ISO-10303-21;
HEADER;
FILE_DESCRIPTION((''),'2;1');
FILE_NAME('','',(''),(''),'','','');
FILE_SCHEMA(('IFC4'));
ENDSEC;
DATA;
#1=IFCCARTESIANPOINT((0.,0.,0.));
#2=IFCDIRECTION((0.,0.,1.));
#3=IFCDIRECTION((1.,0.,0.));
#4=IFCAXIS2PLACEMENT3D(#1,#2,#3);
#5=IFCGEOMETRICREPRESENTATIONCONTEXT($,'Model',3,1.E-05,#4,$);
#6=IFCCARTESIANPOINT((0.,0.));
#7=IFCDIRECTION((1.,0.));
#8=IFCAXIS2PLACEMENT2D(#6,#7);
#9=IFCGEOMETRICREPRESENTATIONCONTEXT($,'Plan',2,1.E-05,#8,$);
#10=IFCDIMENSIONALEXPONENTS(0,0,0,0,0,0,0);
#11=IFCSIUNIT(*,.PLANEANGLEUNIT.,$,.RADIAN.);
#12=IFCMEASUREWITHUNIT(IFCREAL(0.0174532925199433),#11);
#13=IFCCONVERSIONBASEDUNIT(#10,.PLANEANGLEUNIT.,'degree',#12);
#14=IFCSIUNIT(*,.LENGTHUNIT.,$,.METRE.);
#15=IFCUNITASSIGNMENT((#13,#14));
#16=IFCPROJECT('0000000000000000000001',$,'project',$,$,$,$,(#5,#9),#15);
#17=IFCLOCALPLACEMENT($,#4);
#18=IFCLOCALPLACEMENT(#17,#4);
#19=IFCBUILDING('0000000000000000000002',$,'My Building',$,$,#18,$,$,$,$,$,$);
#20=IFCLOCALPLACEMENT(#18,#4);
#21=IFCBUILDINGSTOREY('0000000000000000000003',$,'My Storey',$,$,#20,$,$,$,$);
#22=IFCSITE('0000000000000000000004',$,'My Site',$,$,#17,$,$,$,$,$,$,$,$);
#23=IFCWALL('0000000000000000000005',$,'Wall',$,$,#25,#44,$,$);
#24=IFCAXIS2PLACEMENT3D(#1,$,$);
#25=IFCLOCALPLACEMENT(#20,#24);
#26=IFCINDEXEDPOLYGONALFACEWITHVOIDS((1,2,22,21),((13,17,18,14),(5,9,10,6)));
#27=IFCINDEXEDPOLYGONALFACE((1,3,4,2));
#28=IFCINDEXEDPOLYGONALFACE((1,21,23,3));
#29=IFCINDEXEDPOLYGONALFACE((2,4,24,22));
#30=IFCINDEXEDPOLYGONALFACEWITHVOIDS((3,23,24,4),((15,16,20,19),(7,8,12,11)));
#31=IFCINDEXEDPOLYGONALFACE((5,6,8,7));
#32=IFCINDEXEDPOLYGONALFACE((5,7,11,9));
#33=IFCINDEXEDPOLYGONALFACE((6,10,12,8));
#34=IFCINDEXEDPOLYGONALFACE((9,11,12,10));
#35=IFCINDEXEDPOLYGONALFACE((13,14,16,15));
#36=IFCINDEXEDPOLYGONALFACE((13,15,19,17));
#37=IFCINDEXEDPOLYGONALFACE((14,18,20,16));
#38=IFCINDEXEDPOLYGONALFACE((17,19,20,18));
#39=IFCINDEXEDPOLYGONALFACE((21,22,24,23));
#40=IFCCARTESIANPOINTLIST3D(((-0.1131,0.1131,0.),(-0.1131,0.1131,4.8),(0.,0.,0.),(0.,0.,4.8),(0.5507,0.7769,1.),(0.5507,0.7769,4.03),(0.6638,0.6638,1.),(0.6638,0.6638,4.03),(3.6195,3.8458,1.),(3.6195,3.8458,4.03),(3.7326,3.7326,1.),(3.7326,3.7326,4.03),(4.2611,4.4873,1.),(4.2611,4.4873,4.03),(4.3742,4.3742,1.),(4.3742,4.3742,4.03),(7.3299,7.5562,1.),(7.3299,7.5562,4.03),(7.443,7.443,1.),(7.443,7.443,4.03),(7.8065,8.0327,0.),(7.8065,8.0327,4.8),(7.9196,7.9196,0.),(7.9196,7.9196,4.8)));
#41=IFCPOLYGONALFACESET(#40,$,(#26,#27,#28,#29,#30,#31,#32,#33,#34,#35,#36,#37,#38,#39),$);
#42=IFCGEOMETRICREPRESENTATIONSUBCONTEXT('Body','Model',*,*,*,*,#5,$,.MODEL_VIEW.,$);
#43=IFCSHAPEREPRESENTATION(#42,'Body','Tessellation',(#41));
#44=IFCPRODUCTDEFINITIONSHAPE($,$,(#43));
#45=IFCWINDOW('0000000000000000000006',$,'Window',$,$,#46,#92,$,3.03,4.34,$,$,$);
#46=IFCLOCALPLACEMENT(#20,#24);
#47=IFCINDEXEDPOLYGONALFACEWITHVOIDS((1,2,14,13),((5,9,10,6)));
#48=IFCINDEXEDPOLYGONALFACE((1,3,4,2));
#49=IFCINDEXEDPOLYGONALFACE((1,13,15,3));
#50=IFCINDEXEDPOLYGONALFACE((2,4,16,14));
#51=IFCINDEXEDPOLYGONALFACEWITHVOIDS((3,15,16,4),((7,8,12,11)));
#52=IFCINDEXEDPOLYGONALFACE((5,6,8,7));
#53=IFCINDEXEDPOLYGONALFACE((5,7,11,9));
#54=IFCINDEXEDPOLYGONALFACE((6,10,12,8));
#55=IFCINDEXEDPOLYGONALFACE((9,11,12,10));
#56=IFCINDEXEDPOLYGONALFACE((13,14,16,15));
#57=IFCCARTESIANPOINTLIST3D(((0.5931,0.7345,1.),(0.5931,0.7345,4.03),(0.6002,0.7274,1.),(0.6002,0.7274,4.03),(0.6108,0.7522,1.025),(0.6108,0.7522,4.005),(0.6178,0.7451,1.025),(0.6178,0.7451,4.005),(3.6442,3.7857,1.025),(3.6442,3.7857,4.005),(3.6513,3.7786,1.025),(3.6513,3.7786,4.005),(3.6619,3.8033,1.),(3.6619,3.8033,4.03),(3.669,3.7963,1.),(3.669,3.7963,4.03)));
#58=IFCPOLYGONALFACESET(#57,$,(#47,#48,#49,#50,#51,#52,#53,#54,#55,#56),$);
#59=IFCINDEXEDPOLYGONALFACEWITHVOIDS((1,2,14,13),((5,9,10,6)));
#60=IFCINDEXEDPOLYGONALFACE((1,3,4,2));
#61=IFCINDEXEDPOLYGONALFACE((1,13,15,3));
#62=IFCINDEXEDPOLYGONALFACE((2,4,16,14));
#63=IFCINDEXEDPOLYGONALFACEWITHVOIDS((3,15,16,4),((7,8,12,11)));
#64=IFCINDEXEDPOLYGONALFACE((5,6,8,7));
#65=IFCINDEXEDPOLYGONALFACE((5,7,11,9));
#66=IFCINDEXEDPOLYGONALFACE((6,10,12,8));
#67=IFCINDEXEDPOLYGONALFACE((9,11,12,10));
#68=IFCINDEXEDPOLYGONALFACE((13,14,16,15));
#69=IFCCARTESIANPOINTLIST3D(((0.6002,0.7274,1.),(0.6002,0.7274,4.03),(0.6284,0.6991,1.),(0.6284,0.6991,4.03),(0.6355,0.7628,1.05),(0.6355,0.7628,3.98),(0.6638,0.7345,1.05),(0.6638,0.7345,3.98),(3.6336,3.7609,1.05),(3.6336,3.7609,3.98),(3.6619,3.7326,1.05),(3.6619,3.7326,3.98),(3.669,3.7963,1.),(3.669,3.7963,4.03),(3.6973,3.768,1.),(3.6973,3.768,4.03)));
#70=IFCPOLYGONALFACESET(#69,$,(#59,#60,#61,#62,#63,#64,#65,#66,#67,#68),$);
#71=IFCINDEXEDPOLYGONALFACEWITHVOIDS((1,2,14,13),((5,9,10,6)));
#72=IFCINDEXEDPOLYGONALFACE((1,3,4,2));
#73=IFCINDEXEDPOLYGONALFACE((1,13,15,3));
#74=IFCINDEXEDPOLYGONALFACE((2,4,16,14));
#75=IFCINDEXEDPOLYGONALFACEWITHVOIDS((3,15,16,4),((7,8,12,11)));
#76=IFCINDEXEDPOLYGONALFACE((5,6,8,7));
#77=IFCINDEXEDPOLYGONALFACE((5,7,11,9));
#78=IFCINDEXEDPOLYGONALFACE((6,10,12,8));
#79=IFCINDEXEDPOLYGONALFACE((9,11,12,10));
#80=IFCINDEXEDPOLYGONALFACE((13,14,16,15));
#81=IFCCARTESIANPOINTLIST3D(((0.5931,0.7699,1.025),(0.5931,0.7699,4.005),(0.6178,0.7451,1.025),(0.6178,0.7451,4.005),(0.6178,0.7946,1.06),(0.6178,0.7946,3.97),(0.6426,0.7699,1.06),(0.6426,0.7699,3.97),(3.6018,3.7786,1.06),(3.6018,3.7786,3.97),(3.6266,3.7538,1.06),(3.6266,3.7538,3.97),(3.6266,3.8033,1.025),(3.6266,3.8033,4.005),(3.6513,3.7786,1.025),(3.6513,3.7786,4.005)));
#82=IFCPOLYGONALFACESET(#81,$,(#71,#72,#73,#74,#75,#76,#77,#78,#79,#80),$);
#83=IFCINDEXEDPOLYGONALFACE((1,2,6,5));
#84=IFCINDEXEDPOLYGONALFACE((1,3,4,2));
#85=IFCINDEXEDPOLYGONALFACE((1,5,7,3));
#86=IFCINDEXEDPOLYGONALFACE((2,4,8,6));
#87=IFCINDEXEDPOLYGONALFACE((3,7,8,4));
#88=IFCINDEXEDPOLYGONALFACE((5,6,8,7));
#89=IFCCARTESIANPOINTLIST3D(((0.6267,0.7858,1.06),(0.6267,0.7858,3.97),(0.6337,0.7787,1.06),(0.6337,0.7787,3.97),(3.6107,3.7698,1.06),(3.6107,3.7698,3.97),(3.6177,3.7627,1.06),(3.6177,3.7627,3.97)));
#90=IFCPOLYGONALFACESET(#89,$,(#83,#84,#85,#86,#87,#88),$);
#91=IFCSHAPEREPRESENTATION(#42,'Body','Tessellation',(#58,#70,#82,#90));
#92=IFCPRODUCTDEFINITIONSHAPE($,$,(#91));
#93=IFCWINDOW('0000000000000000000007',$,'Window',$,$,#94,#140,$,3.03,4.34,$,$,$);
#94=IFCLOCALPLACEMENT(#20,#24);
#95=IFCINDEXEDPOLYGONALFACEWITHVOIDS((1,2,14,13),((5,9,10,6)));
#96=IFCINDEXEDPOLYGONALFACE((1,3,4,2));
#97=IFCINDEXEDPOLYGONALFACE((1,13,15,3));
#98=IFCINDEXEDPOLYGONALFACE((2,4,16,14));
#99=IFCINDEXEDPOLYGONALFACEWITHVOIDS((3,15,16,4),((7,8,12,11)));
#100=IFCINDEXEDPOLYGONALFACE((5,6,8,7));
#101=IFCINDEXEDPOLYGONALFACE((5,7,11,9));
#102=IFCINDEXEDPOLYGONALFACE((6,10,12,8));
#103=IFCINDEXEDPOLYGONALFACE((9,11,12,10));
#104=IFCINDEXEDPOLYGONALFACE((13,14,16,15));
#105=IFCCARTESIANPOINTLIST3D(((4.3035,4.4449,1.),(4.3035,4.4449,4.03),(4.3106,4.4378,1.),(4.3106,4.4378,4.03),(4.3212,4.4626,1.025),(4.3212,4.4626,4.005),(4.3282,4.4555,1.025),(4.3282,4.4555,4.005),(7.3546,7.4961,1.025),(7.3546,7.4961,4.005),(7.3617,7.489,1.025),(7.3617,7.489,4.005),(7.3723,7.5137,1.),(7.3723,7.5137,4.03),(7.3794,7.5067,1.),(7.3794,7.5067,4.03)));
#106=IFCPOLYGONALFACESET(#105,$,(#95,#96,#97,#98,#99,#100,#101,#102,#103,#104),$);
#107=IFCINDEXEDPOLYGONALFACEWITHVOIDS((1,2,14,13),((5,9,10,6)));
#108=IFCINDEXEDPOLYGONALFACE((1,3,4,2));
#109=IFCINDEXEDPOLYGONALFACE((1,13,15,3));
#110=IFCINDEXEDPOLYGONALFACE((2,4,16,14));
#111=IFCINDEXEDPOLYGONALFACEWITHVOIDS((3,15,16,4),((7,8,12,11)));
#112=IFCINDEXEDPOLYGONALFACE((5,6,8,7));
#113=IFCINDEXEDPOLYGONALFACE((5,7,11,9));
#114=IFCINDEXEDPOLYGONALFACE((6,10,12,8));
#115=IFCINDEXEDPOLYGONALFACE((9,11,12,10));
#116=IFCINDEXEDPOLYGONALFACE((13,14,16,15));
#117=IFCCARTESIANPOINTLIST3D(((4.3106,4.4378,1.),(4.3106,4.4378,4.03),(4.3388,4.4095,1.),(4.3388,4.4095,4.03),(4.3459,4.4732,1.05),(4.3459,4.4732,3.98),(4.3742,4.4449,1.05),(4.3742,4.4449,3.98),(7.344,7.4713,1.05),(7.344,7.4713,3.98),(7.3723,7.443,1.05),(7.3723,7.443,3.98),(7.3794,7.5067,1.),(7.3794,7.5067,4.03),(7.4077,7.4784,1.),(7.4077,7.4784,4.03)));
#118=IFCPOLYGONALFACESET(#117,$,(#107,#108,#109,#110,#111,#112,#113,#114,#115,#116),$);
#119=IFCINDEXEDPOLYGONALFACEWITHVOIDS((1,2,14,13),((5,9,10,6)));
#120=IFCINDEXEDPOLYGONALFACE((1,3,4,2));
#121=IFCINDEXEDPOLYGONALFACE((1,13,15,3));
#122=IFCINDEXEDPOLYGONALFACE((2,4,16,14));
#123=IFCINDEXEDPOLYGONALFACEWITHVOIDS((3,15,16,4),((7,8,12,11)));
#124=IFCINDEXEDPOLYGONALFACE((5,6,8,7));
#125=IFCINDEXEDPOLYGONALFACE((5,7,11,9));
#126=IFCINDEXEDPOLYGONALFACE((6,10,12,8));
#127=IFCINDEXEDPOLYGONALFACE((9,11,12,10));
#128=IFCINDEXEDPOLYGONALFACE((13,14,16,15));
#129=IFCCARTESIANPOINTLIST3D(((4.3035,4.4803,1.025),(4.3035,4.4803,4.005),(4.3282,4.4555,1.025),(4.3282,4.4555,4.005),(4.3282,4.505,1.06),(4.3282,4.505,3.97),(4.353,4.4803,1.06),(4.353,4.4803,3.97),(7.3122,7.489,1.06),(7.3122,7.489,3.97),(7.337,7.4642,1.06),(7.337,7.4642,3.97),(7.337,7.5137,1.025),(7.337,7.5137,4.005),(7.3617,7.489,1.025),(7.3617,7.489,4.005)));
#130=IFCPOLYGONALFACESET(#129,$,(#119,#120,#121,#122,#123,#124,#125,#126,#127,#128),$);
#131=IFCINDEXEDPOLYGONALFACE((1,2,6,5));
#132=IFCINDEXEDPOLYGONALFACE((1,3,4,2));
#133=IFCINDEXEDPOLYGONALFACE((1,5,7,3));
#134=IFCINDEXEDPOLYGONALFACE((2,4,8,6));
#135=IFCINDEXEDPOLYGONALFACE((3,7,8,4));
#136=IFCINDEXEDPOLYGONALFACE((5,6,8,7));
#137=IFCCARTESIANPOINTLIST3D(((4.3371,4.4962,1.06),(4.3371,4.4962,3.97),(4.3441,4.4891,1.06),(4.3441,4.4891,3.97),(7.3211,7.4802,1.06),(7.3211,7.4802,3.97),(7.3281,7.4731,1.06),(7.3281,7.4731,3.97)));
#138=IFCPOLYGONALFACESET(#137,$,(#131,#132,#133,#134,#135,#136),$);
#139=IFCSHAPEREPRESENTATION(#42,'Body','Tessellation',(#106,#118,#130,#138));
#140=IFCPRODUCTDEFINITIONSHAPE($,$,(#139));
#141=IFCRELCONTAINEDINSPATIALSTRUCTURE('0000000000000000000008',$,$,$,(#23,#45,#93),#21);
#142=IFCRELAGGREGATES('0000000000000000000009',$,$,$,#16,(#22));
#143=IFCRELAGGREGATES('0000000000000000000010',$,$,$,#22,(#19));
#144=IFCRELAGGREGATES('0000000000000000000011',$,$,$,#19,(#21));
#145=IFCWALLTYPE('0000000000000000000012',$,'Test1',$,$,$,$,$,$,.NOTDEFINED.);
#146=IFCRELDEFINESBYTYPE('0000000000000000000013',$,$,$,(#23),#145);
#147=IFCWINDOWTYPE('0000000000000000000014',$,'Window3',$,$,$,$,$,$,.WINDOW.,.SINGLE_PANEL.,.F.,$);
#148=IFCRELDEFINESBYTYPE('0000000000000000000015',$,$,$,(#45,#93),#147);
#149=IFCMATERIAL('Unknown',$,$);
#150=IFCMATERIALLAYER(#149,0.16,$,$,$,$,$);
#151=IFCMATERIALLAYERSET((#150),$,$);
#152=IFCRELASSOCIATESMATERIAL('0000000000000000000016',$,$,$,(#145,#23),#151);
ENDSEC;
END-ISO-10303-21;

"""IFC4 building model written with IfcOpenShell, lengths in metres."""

from ifc_helpers import new_model, entity, si_unit, converted_unit, frame, origin_with_axes, origin_2d_with_axis, place, context, subcontext, project, spatial, line, indexed_curve, outline, extrude, shape, source, transform, mapped, material, layer, layer_set, layer_usage, type_object, type_shapes, element, fill, save


model = new_model("IFC4")

# Units and contexts
model_context = context("Model", 3, precision=1e-05, world=origin_with_axes())
plan_context = context("Plan", 2, precision=1e-05, world=origin_2d_with_axis())
body_context_1 = subcontext(model_context, "Body", "Model", "MODEL_VIEW")
body_context_2 = subcontext(plan_context, "Body", "Plan", "PLAN_VIEW")
ifc_project = project(units=[converted_unit("PLANEANGLEUNIT", "degree", entity("IfcReal", 0.0174532925199433), si_unit("PLANEANGLEUNIT", "RADIAN"), dimensions=[0, 0, 0, 0, 0, 0, 0]), si_unit("LENGTHUNIT", "METRE")], contexts=[model_context, plan_context])

# Site, building, storey
site_placement = place(None, origin_with_axes())
site = spatial("IfcSite", under=ifc_project, at=site_placement, Name="My Site")
building_placement = place(site_placement, origin_with_axes())
building = spatial("IfcBuilding", under=site, at=building_placement, Name="My Building")
storey_placement = place(building_placement, origin_with_axes())
storey = spatial("IfcBuildingStorey", under=building, at=storey_placement, Name="My Storey")

# Wall, openings, windows
ifc_material = material(Name="Unknown")
ifc_layer = layer(ifc_material, 0.16)
ifc_layer_set = layer_set([ifc_layer])
ifc_layer_usage_1 = layer_usage(ifc_layer_set, "AXIS2", "POSITIVE", 0.0)
wall_type = type_object("IfcWallType", Name="Test1", PredefinedType="NOTDEFINED", material=ifc_layer_set)
wall_1_placement = place(storey_placement, frame((0.0, 0.0, 0.0), z_axis=(0.0, 0.0, 1.0), x_axis=(0.707107, 0.707107, 0.0)))
wall_1 = element("IfcWall", 1, at=wall_1_placement, inside=storey, type_object=wall_type, material=ifc_layer_usage_1, Name="Wall", context=body_context_1, shape_type="SweptSolid", body=[
    extrude(outline(indexed_curve([(0.0, 0.0), (0.0, 0.16), (11.2, 0.16), (11.2, 0.0), (0.0, 0.0)], self_intersect=False)), origin_with_axes(), (0.0, 0.0, 1.0), 4.8),
])
shared_shape_1 = source(origin_with_axes(), body_context_1, "Body", "SweptSolid", [
    extrude(outline(indexed_curve([(0.0, 0.0), (4.34, 0.0), (4.34, 3.03), (0.0, 3.03)], segments=[line(1, 2, 3, 4, 1)])), frame((0.0, -0.1, 0.0), z_axis=(0.0, -1.0, 0.0), x_axis=(1.0, 0.0, 0.0)), (0.0, 0.0, -1.0), 0.36),
])
opening_1_placement = place(wall_1_placement, frame((0.9387, 0.0, 1.0), z_axis=(0.0, 0.0, 1.0), x_axis=(1.0, 0.0, 0.0)))
opening_1 = element("IfcOpeningElement", 2, at=opening_1_placement, cuts=wall_1, PredefinedType="OPENING", context=body_context_1, shape_type="MappedRepresentation", body=[
    mapped(shared_shape_1, transform((0.0, 0.0, 0.0), x_axis=(1.0, 0.0, 0.0), y_axis=(0.0, 1.0, 0.0), z_axis=(0.0, 0.0, 1.0), scale=1.0)),
])
opening_2_placement = place(wall_1_placement, frame((6.186, 0.0, 1.0), z_axis=(0.0, 0.0, 1.0), x_axis=(1.0, 0.0, 0.0)))
opening_2 = element("IfcOpeningElement", 3, at=opening_2_placement, cuts=wall_1, PredefinedType="OPENING", context=body_context_1, shape_type="MappedRepresentation", body=[
    mapped(shared_shape_1, transform((0.0, 0.0, 0.0), x_axis=(1.0, 0.0, 0.0), y_axis=(0.0, 1.0, 0.0), z_axis=(0.0, 0.0, 1.0), scale=1.0)),
])
window_type = type_object("IfcWindowType", Name="Window3", ParameterTakesPrecedence=False, PartitioningType="SINGLE_PANEL", PredefinedType="WINDOW")
shared_shape_2 = source(origin_with_axes(), body_context_1, "Body", "SweptSolid", [
    extrude(outline(indexed_curve([(0.0, 0.0), (4.34, 0.0), (4.34, 3.03), (0.0, 3.03)], segments=[line(1, 2, 3, 4, 1)]), holes=[indexed_curve([(0.025, 0.025), (4.315, 0.025), (4.315, 3.005), (0.025, 3.005)], segments=[line(1, 2, 3, 4, 1)])]), frame((0.0, 0.09, 0.0), z_axis=(0.0, -1.0, 0.0), x_axis=(1.0, 0.0, 0.0)), (0.0, 0.0, -1.0), 0.01),
    extrude(outline(indexed_curve([(0.0, 0.0), (4.34, 0.0), (4.34, 3.03), (0.0, 3.03)], segments=[line(1, 2, 3, 4, 1)]), holes=[indexed_curve([(0.05, 0.05), (4.29, 0.05), (4.29, 2.98), (0.05, 2.98)], segments=[line(1, 2, 3, 4, 1)])]), frame((0.0, 0.05, 0.0), z_axis=(0.0, -1.0, 0.0), x_axis=(1.0, 0.0, 0.0)), (0.0, 0.0, -1.0), 0.04),
    extrude(outline(indexed_curve([(0.0, 0.0), (4.29, 0.0), (4.29, 2.98), (0.0, 2.98)], segments=[line(1, 2, 3, 4, 1)]), holes=[indexed_curve([(0.035, 0.035), (4.255, 0.035), (4.255, 2.945), (0.035, 2.945)], segments=[line(1, 2, 3, 4, 1)])]), frame((0.025, 0.09, 0.025), z_axis=(0.0, -1.0, 0.0), x_axis=(1.0, 0.0, 0.0)), (0.0, 0.0, -1.0), 0.035),
    extrude(outline(indexed_curve([(0.035, 0.035), (4.255, 0.035), (4.255, 2.945), (0.035, 2.945)], segments=[line(1, 2, 3, 4, 1)])), frame((0.025, 0.1025, 0.025), z_axis=(0.0, -1.0, 0.0), x_axis=(1.0, 0.0, 0.0)), (0.0, 0.0, -1.0), 0.01),
])
shared_shape_3 = source(origin_with_axes(), body_context_2, "Body", "Curve2D", [
    entity("IfcIndexedPolyCurve", entity("IfcCartesianPointList2D", [[0.05, 0.05], [4.29, 0.05]])),
    entity("IfcIndexedPolyCurve", entity("IfcCartesianPointList2D", [[0.0, 0.1], [0.025, 0.1], [0.025, 0.09], [0.05, 0.09], [0.05, 0.05], [0.0, 0.05]]), [entity("IfcLineIndex", [1, 2, 3, 4, 5, 6, 1])]),
    entity("IfcIndexedPolyCurve", entity("IfcCartesianPointList2D", [[4.34, 0.1], [4.315, 0.1], [4.315, 0.09], [4.29, 0.09], [4.29, 0.05], [4.34, 0.05]]), [entity("IfcLineIndex", [1, 2, 3, 4, 5, 6, 1])]),
    entity("IfcIndexedPolyCurve", entity("IfcCartesianPointList2D", [[0.025, 0.09], [0.06, 0.09], [0.06, 0.125], [0.025, 0.125]]), [entity("IfcLineIndex", [1, 2, 3, 4, 1])]),
    entity("IfcIndexedPolyCurve", entity("IfcCartesianPointList2D", [[4.315, 0.09], [4.28, 0.09], [4.28, 0.125], [4.315, 0.125]]), [entity("IfcLineIndex", [1, 2, 3, 4, 1])]),
    entity("IfcIndexedPolyCurve", entity("IfcCartesianPointList2D", [[0.06, 0.09], [4.28, 0.09]])),
    entity("IfcIndexedPolyCurve", entity("IfcCartesianPointList2D", [[0.06, 0.125], [4.28, 0.125]])),
    entity("IfcIndexedPolyCurve", entity("IfcCartesianPointList2D", [[0.06, 0.1075], [4.28, 0.1075]])),
])
type_shapes(window_type, [shared_shape_2, shared_shape_3])
window_1_placement = place(opening_1_placement, origin_with_axes())
window_1 = element("IfcWindow", 4, at=window_1_placement, inside=storey, type_object=window_type, Name="Window", OverallHeight=3.03, OverallWidth=4.34, shapes=[
    shape(body_context_1, "Body", "MappedRepresentation", [mapped(shared_shape_2, transform((0.0, 0.0, 0.0), x_axis=(1.0, 0.0, 0.0), y_axis=(0.0, 1.0, 0.0), z_axis=(0.0, 0.0, 1.0), scale=1.0))]),
    shape(body_context_2, "Body", "MappedRepresentation", [mapped(shared_shape_3, transform((0.0, 0.0, 0.0), x_axis=(1.0, 0.0, 0.0), y_axis=(0.0, 1.0, 0.0), z_axis=(0.0, 0.0, 1.0), scale=1.0))]),
])
fill(opening_1, window_1)
window_2_placement = place(opening_2_placement, origin_with_axes())
window_2 = element("IfcWindow", 5, at=window_2_placement, inside=storey, type_object=window_type, Name="Window", OverallHeight=3.03, OverallWidth=4.34, shapes=[
    shape(body_context_1, "Body", "MappedRepresentation", [mapped(shared_shape_2, transform((0.0, 0.0, 0.0), x_axis=(1.0, 0.0, 0.0), y_axis=(0.0, 1.0, 0.0), z_axis=(0.0, 0.0, 1.0), scale=1.0))]),
    shape(body_context_2, "Body", "MappedRepresentation", [mapped(shared_shape_3, transform((0.0, 0.0, 0.0), x_axis=(1.0, 0.0, 0.0), y_axis=(0.0, 1.0, 0.0), z_axis=(0.0, 0.0, 1.0), scale=1.0))]),
])
fill(opening_2, window_2)

save(model, "model.ifc")
